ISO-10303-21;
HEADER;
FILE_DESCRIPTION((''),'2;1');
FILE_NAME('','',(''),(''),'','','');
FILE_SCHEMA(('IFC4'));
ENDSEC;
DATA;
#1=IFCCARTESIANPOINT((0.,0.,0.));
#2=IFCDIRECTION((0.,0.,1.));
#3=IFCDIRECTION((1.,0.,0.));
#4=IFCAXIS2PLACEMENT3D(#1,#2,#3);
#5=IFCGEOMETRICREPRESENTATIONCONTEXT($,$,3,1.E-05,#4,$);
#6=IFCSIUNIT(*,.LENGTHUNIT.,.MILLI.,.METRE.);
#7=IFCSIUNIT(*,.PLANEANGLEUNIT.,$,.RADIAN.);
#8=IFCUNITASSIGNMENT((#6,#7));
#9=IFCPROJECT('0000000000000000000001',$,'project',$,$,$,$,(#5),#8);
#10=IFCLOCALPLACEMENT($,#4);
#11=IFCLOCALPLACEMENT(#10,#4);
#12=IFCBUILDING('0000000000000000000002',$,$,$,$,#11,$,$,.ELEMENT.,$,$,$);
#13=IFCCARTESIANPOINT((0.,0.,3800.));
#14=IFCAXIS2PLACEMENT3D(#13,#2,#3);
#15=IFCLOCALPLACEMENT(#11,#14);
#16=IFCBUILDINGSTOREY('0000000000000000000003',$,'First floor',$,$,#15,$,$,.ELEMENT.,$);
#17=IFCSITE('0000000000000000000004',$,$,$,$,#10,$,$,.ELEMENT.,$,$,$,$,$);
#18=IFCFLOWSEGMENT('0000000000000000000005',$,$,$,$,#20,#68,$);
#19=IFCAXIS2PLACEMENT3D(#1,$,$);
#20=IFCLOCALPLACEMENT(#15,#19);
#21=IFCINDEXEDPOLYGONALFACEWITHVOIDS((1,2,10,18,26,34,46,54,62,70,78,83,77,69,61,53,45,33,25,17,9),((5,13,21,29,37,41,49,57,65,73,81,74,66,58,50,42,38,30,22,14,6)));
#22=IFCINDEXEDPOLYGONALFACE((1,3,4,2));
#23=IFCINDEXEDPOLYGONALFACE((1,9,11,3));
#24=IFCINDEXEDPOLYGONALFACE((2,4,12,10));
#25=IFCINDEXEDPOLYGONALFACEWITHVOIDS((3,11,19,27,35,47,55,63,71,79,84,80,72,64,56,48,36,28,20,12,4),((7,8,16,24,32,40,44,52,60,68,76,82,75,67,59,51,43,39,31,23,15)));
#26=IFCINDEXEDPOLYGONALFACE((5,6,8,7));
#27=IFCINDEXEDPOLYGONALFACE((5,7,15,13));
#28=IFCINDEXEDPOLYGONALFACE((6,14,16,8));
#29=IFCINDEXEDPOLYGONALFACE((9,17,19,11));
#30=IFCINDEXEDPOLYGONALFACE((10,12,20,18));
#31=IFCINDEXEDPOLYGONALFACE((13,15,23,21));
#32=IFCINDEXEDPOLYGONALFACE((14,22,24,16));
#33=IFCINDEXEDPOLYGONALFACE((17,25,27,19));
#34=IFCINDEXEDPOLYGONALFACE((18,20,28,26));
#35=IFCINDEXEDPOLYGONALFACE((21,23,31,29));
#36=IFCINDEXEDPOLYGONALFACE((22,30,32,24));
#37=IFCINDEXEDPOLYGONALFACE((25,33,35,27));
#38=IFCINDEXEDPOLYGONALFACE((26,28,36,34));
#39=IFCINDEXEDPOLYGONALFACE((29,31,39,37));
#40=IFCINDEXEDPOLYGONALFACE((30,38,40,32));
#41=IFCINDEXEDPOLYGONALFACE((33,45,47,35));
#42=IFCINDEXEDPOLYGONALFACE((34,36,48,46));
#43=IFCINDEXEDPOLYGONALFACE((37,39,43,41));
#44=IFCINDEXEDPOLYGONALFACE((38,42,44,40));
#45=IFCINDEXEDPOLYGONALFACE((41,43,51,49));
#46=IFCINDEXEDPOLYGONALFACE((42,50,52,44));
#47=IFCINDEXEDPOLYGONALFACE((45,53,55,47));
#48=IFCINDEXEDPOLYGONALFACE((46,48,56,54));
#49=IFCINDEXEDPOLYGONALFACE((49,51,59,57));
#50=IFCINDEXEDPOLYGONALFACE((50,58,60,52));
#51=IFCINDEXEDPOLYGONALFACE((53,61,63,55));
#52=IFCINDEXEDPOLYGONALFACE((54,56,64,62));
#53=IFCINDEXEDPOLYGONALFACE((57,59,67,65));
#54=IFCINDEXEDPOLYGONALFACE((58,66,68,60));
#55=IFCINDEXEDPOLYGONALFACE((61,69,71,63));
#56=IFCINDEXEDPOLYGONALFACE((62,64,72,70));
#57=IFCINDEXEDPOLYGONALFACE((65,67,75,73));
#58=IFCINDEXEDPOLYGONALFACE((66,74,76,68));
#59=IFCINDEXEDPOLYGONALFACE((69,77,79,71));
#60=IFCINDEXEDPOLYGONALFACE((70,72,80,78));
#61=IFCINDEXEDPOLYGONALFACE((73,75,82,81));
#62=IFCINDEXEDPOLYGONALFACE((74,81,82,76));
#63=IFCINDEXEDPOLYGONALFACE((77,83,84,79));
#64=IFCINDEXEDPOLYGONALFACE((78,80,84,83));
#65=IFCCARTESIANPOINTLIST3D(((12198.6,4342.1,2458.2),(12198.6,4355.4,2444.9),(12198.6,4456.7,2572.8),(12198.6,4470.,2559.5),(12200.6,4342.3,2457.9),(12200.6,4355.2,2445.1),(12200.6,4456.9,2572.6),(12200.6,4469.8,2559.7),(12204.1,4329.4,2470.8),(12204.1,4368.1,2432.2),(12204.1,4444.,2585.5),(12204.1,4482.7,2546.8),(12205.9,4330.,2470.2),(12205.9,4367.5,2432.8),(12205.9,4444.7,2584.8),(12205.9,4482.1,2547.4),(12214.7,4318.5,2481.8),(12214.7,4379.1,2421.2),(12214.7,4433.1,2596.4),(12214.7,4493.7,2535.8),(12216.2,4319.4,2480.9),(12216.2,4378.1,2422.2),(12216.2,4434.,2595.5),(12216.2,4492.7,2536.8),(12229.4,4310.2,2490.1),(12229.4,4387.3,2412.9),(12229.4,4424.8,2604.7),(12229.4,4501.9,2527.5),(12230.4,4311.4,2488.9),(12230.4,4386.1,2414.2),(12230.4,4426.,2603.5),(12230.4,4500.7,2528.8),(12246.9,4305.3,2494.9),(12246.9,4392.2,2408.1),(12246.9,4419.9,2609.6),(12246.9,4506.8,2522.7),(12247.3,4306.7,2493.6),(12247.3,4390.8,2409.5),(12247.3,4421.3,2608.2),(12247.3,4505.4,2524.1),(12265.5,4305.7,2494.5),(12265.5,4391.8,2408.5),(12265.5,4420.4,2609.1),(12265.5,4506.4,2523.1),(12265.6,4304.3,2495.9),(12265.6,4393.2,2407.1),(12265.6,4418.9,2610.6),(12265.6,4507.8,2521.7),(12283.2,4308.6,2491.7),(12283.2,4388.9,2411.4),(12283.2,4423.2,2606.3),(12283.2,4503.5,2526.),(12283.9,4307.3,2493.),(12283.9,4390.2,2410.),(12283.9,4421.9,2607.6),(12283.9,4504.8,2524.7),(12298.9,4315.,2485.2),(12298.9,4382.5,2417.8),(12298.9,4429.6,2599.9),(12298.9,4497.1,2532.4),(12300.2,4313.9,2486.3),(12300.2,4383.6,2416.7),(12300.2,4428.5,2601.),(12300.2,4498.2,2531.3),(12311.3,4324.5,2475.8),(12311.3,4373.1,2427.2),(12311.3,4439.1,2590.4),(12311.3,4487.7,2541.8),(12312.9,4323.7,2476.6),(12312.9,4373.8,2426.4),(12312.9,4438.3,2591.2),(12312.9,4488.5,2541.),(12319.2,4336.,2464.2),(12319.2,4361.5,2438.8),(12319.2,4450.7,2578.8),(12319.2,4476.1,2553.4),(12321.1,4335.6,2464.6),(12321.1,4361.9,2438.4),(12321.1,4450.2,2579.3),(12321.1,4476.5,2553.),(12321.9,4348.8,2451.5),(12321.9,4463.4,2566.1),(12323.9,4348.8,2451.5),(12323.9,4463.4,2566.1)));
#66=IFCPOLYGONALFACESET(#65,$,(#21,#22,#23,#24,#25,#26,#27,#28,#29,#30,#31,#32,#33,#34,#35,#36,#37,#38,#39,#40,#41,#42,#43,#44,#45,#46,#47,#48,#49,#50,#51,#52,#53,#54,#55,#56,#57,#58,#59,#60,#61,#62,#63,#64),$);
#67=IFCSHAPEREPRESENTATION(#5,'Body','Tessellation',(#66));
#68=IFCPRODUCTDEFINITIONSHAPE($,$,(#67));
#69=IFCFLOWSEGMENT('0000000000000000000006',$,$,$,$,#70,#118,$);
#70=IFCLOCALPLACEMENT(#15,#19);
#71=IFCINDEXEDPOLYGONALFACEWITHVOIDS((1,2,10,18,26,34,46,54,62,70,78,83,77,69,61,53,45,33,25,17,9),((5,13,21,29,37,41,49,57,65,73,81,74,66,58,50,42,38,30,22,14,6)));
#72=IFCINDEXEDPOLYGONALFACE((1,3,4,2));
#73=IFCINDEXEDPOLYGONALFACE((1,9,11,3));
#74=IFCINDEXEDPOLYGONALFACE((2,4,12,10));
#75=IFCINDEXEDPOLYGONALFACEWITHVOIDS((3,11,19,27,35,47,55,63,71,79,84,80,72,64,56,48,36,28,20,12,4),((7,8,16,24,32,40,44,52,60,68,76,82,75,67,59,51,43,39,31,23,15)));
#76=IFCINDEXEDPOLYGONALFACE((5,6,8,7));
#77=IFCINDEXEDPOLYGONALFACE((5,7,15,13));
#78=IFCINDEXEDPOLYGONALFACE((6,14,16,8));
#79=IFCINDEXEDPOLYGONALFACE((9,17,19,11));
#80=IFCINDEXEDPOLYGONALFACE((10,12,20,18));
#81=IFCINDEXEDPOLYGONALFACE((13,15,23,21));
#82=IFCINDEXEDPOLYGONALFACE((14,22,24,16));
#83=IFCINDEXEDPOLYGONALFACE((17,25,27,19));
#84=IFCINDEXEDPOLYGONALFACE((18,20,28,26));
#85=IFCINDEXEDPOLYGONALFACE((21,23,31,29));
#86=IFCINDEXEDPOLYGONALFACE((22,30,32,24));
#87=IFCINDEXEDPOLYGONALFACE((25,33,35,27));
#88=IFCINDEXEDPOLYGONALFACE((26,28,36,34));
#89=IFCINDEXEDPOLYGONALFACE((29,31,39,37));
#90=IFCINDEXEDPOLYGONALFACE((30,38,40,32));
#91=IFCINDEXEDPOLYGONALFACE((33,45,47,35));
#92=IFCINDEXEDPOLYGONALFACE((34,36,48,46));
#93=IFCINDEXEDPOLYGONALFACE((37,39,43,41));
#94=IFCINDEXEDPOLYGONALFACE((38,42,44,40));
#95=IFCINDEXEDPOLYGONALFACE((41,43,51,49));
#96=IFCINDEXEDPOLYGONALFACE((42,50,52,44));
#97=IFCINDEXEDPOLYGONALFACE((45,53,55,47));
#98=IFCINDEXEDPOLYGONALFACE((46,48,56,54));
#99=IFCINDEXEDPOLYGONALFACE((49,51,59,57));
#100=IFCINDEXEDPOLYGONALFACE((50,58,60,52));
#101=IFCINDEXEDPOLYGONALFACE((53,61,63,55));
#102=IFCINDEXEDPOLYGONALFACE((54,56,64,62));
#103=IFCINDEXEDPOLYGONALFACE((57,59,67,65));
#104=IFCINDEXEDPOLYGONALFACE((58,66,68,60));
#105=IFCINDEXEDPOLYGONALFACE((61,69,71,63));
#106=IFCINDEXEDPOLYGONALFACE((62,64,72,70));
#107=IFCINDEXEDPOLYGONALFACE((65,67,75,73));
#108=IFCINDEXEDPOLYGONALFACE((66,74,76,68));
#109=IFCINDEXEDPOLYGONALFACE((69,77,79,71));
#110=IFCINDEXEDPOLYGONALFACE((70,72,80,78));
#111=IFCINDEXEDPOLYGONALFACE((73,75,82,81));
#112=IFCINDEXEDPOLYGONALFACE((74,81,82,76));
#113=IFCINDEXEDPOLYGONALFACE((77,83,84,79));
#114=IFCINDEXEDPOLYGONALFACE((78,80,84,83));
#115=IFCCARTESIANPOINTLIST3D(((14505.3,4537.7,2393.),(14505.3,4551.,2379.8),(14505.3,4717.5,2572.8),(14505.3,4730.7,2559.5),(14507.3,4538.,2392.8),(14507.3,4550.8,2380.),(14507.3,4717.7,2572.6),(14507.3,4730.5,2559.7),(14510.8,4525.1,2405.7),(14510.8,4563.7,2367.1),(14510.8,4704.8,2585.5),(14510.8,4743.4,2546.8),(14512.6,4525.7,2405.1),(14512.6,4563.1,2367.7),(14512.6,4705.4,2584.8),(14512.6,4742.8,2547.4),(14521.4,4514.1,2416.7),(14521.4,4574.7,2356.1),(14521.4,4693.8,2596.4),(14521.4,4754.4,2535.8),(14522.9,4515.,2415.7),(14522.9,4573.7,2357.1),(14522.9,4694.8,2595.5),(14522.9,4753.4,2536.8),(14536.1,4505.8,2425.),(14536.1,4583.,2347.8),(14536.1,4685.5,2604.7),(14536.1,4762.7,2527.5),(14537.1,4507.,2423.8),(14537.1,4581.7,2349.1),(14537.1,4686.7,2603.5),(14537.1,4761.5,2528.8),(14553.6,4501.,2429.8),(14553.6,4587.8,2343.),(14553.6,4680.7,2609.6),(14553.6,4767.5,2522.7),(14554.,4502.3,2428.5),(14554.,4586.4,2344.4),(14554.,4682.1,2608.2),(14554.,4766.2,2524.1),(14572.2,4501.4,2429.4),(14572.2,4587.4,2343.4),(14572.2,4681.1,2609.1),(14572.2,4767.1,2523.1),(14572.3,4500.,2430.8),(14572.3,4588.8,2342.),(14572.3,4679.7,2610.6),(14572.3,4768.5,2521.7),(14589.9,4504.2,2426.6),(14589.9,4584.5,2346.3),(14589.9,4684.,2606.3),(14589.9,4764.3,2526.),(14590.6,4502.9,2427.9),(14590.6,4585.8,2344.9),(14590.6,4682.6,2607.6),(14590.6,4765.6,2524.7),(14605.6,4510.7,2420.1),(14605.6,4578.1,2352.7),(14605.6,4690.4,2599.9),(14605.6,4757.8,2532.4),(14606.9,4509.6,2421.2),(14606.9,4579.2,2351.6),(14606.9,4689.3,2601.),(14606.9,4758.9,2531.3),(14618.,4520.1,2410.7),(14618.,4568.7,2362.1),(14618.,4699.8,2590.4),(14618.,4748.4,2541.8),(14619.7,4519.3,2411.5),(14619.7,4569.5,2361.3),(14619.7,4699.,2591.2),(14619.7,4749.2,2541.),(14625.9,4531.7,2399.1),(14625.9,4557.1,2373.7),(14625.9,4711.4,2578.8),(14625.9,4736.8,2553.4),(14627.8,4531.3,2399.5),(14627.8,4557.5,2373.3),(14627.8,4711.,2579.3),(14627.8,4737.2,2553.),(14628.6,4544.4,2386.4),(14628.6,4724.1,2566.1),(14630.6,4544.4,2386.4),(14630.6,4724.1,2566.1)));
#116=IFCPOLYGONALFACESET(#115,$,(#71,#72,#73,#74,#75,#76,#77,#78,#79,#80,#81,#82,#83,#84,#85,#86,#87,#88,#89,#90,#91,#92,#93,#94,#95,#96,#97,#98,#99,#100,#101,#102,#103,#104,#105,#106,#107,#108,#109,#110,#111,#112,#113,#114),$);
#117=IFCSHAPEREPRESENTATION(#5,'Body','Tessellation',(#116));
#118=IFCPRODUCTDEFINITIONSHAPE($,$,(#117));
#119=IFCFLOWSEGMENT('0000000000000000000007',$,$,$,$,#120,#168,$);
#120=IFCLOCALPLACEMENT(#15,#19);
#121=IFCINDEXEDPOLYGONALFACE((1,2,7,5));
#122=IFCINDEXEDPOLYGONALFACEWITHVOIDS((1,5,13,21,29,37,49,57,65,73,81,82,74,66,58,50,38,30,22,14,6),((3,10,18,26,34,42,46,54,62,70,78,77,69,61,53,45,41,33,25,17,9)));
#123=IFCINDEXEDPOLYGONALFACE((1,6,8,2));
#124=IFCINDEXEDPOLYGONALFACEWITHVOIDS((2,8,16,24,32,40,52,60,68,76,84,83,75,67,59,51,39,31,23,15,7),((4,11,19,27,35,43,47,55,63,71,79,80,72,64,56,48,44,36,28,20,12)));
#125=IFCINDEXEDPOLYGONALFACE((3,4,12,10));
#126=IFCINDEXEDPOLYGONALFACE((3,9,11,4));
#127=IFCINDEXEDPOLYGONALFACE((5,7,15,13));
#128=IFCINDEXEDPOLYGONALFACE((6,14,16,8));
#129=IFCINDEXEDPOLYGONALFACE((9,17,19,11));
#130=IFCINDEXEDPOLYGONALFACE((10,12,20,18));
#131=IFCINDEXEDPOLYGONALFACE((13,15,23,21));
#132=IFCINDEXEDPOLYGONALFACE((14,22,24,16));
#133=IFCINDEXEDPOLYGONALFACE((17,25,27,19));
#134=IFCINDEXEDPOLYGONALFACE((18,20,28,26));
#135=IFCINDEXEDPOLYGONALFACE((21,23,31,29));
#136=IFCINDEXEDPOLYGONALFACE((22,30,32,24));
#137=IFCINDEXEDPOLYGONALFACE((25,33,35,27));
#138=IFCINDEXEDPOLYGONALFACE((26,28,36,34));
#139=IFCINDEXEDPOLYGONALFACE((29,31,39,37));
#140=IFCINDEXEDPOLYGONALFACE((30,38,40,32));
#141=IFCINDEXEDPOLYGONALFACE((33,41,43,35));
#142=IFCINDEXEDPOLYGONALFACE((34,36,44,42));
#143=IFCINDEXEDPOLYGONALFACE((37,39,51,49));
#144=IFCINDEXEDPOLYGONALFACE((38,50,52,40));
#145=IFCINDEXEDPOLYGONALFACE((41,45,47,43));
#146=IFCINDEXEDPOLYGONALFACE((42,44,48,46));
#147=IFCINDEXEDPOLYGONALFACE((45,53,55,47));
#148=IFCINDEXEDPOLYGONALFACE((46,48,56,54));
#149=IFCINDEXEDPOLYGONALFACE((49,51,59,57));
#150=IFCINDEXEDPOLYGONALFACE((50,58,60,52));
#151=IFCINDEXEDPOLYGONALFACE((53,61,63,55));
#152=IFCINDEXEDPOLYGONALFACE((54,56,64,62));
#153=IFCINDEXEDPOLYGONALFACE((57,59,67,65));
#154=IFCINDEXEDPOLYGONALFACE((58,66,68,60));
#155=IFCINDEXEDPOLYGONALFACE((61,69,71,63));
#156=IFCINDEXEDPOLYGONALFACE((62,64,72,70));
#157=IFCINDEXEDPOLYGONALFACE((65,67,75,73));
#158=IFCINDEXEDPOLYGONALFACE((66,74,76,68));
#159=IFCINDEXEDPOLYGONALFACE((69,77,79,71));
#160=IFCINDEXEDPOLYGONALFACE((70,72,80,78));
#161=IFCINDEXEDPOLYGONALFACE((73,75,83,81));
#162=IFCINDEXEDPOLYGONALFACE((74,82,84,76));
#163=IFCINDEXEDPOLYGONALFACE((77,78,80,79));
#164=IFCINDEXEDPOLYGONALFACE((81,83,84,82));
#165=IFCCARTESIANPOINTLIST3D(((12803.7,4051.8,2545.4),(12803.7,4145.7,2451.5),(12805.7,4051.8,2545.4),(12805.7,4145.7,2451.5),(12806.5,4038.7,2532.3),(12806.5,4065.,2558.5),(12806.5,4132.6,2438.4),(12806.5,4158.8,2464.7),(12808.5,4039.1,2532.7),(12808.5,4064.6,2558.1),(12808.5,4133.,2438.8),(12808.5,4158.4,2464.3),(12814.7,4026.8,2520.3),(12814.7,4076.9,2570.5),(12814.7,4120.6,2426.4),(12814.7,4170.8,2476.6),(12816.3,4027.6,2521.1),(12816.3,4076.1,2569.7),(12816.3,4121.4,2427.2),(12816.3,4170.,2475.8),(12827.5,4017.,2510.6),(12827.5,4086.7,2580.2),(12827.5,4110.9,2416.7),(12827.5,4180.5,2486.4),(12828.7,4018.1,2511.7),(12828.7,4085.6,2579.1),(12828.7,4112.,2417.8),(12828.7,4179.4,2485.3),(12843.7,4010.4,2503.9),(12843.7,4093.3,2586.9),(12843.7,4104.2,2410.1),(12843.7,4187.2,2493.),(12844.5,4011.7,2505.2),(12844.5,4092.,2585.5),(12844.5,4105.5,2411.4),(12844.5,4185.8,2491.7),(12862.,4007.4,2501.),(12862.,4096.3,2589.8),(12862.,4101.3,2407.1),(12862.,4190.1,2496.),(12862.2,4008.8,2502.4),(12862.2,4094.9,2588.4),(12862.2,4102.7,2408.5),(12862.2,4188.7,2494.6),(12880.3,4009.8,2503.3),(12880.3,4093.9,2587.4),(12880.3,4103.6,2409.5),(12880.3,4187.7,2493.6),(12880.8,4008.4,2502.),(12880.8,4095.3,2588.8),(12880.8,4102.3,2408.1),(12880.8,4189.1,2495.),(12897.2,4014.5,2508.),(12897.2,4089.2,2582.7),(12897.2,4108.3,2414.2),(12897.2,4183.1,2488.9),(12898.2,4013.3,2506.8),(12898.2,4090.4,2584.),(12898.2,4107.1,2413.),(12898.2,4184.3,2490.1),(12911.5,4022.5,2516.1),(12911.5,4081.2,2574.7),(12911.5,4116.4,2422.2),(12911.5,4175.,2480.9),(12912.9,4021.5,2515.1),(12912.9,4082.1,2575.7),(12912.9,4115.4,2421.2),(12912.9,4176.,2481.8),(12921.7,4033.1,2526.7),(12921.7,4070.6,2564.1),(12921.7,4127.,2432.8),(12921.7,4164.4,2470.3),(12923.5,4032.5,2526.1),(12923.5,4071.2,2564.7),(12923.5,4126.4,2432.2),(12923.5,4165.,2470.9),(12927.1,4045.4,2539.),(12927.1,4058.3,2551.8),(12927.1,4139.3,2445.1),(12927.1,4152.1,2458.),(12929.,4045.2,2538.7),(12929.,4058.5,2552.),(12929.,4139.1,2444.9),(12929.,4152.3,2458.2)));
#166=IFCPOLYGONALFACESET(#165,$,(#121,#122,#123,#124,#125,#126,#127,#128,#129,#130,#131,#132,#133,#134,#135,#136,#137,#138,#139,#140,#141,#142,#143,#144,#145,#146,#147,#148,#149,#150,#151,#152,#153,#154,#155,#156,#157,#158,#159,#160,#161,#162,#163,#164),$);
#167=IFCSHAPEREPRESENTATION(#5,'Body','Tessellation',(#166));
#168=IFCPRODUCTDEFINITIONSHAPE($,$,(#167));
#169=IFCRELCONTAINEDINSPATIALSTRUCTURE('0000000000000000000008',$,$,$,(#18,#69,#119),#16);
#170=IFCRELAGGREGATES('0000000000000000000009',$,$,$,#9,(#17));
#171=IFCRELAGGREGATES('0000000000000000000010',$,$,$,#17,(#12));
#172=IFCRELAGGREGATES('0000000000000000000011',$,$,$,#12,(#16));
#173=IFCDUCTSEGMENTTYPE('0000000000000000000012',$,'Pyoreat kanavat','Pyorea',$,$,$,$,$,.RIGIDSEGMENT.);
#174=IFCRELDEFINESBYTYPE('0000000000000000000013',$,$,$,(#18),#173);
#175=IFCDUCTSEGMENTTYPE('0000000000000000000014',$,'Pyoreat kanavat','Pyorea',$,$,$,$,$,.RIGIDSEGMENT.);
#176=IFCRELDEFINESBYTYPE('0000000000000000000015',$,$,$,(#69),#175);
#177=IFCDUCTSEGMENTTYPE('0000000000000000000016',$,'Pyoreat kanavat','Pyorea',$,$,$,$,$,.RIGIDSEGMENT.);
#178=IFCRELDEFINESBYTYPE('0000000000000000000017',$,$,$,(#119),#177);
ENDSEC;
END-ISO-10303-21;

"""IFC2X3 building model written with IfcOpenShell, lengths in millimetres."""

from ifc_helpers import new_model, si_unit, frame, origin_with_axes, origin_2d_with_axis, place, context, project, spatial, hollow_circle, extrude, source, transform, mapped, type_object, element, save


model = new_model("IFC2X3")

# Units and contexts
context_of_model = context(None, 3, precision=1e-05, world=origin_with_axes())
ifc_project = project(units=[si_unit("LENGTHUNIT", "METRE", prefix="MILLI"), si_unit("PLANEANGLEUNIT", "RADIAN")], contexts=[context_of_model])

# Site, building, storey
site_placement = place(None, origin_with_axes())
site = spatial("IfcSite", under=ifc_project, at=site_placement, CompositionType="ELEMENT")
building_placement = place(site_placement, origin_with_axes())
building = spatial("IfcBuilding", under=site, at=building_placement, CompositionType="ELEMENT")
storey_placement = place(building_placement, frame((0.0, 0.0, 3800.0), z_axis=(0.0, 0.0, 1.0), x_axis=(1.0, 0.0, 0.0)))
storey = spatial("IfcBuildingStorey", under=building, at=storey_placement, Name="First floor", CompositionType="ELEMENT")

# Flow segments
duct_segment_type_1 = type_object("IfcDuctSegmentType", Name="Pyoreat kanavat", Description="Pyorea", PredefinedType="RIGIDSEGMENT")
shared_shape_1 = source(origin_with_axes(), context_of_model, "Body", "SweptSolid", [
    extrude(hollow_circle(Radius=63.0, WallThickness=2.0, at=origin_2d_with_axis()), frame((0.0, 0.0, 0.0), z_axis=(1.0, 0.0, 0.0), x_axis=(0.0, 1.0, 0.0)), (0.0, 0.0, 1.0), 306.0),
])
flow_segment_1_placement = place(storey_placement, frame((12260.9, 4463.4, 2566.1), z_axis=(0.0, -0.707107, 0.707107), x_axis=(0.0, -0.707107, -0.707107)))
element("IfcFlowSegment", 1, at=flow_segment_1_placement, inside=storey, type_object=duct_segment_type_1, context=context_of_model, shape_type="MappedRepresentation", body=[
    mapped(shared_shape_1, transform((0.0, 0.0, 0.0), scale=0.529696, scale2=1.0, scale3=1.0, uniform=False)),
])
duct_segment_type_2 = type_object("IfcDuctSegmentType", Name="Pyoreat kanavat", Description="Pyorea", PredefinedType="RIGIDSEGMENT")
shared_shape_2 = source(origin_with_axes(), context_of_model, "Body", "SweptSolid", [
    extrude(hollow_circle(Radius=63.0, WallThickness=2.0, at=origin_2d_with_axis()), frame((0.0, 0.0, 0.0), z_axis=(1.0, 0.0, 0.0), x_axis=(0.0, 1.0, 0.0)), (0.0, 0.0, 1.0), 306.0),
])
flow_segment_2_placement = place(storey_placement, frame((14567.6, 4724.1, 2566.1), z_axis=(0.0, -0.707107, 0.707107), x_axis=(0.0, -0.707107, -0.707107)))
element("IfcFlowSegment", 2, at=flow_segment_2_placement, inside=storey, type_object=duct_segment_type_2, context=context_of_model, shape_type="MappedRepresentation", body=[
    mapped(shared_shape_2, transform((0.0, 0.0, 0.0), scale=0.830603, scale2=1.0, scale3=1.0, uniform=False)),
])
duct_segment_type_3 = type_object("IfcDuctSegmentType", Name="Pyoreat kanavat", Description="Pyorea", PredefinedType="RIGIDSEGMENT")
shared_shape_3 = source(origin_with_axes(), context_of_model, "Body", "SweptSolid", [
    extrude(hollow_circle(Radius=63.0, WallThickness=2.0, at=origin_2d_with_axis()), frame((0.0, 0.0, 0.0), z_axis=(1.0, 0.0, 0.0), x_axis=(0.0, 1.0, 0.0)), (0.0, 0.0, 1.0), 306.0),
])
flow_segment_3_placement = place(storey_placement, frame((12866.7, 4051.8, 2545.4), z_axis=(0.0, 0.707107, 0.707107), x_axis=(0.0, 0.707107, -0.707107)))
element("IfcFlowSegment", 3, at=flow_segment_3_placement, inside=storey, type_object=duct_segment_type_3, context=context_of_model, shape_type="MappedRepresentation", body=[
    mapped(shared_shape_3, transform((0.0, 0.0, 0.0), scale=0.43373, scale2=1.0, scale3=1.0, uniform=False)),
])

save(model, "model.ifc")
